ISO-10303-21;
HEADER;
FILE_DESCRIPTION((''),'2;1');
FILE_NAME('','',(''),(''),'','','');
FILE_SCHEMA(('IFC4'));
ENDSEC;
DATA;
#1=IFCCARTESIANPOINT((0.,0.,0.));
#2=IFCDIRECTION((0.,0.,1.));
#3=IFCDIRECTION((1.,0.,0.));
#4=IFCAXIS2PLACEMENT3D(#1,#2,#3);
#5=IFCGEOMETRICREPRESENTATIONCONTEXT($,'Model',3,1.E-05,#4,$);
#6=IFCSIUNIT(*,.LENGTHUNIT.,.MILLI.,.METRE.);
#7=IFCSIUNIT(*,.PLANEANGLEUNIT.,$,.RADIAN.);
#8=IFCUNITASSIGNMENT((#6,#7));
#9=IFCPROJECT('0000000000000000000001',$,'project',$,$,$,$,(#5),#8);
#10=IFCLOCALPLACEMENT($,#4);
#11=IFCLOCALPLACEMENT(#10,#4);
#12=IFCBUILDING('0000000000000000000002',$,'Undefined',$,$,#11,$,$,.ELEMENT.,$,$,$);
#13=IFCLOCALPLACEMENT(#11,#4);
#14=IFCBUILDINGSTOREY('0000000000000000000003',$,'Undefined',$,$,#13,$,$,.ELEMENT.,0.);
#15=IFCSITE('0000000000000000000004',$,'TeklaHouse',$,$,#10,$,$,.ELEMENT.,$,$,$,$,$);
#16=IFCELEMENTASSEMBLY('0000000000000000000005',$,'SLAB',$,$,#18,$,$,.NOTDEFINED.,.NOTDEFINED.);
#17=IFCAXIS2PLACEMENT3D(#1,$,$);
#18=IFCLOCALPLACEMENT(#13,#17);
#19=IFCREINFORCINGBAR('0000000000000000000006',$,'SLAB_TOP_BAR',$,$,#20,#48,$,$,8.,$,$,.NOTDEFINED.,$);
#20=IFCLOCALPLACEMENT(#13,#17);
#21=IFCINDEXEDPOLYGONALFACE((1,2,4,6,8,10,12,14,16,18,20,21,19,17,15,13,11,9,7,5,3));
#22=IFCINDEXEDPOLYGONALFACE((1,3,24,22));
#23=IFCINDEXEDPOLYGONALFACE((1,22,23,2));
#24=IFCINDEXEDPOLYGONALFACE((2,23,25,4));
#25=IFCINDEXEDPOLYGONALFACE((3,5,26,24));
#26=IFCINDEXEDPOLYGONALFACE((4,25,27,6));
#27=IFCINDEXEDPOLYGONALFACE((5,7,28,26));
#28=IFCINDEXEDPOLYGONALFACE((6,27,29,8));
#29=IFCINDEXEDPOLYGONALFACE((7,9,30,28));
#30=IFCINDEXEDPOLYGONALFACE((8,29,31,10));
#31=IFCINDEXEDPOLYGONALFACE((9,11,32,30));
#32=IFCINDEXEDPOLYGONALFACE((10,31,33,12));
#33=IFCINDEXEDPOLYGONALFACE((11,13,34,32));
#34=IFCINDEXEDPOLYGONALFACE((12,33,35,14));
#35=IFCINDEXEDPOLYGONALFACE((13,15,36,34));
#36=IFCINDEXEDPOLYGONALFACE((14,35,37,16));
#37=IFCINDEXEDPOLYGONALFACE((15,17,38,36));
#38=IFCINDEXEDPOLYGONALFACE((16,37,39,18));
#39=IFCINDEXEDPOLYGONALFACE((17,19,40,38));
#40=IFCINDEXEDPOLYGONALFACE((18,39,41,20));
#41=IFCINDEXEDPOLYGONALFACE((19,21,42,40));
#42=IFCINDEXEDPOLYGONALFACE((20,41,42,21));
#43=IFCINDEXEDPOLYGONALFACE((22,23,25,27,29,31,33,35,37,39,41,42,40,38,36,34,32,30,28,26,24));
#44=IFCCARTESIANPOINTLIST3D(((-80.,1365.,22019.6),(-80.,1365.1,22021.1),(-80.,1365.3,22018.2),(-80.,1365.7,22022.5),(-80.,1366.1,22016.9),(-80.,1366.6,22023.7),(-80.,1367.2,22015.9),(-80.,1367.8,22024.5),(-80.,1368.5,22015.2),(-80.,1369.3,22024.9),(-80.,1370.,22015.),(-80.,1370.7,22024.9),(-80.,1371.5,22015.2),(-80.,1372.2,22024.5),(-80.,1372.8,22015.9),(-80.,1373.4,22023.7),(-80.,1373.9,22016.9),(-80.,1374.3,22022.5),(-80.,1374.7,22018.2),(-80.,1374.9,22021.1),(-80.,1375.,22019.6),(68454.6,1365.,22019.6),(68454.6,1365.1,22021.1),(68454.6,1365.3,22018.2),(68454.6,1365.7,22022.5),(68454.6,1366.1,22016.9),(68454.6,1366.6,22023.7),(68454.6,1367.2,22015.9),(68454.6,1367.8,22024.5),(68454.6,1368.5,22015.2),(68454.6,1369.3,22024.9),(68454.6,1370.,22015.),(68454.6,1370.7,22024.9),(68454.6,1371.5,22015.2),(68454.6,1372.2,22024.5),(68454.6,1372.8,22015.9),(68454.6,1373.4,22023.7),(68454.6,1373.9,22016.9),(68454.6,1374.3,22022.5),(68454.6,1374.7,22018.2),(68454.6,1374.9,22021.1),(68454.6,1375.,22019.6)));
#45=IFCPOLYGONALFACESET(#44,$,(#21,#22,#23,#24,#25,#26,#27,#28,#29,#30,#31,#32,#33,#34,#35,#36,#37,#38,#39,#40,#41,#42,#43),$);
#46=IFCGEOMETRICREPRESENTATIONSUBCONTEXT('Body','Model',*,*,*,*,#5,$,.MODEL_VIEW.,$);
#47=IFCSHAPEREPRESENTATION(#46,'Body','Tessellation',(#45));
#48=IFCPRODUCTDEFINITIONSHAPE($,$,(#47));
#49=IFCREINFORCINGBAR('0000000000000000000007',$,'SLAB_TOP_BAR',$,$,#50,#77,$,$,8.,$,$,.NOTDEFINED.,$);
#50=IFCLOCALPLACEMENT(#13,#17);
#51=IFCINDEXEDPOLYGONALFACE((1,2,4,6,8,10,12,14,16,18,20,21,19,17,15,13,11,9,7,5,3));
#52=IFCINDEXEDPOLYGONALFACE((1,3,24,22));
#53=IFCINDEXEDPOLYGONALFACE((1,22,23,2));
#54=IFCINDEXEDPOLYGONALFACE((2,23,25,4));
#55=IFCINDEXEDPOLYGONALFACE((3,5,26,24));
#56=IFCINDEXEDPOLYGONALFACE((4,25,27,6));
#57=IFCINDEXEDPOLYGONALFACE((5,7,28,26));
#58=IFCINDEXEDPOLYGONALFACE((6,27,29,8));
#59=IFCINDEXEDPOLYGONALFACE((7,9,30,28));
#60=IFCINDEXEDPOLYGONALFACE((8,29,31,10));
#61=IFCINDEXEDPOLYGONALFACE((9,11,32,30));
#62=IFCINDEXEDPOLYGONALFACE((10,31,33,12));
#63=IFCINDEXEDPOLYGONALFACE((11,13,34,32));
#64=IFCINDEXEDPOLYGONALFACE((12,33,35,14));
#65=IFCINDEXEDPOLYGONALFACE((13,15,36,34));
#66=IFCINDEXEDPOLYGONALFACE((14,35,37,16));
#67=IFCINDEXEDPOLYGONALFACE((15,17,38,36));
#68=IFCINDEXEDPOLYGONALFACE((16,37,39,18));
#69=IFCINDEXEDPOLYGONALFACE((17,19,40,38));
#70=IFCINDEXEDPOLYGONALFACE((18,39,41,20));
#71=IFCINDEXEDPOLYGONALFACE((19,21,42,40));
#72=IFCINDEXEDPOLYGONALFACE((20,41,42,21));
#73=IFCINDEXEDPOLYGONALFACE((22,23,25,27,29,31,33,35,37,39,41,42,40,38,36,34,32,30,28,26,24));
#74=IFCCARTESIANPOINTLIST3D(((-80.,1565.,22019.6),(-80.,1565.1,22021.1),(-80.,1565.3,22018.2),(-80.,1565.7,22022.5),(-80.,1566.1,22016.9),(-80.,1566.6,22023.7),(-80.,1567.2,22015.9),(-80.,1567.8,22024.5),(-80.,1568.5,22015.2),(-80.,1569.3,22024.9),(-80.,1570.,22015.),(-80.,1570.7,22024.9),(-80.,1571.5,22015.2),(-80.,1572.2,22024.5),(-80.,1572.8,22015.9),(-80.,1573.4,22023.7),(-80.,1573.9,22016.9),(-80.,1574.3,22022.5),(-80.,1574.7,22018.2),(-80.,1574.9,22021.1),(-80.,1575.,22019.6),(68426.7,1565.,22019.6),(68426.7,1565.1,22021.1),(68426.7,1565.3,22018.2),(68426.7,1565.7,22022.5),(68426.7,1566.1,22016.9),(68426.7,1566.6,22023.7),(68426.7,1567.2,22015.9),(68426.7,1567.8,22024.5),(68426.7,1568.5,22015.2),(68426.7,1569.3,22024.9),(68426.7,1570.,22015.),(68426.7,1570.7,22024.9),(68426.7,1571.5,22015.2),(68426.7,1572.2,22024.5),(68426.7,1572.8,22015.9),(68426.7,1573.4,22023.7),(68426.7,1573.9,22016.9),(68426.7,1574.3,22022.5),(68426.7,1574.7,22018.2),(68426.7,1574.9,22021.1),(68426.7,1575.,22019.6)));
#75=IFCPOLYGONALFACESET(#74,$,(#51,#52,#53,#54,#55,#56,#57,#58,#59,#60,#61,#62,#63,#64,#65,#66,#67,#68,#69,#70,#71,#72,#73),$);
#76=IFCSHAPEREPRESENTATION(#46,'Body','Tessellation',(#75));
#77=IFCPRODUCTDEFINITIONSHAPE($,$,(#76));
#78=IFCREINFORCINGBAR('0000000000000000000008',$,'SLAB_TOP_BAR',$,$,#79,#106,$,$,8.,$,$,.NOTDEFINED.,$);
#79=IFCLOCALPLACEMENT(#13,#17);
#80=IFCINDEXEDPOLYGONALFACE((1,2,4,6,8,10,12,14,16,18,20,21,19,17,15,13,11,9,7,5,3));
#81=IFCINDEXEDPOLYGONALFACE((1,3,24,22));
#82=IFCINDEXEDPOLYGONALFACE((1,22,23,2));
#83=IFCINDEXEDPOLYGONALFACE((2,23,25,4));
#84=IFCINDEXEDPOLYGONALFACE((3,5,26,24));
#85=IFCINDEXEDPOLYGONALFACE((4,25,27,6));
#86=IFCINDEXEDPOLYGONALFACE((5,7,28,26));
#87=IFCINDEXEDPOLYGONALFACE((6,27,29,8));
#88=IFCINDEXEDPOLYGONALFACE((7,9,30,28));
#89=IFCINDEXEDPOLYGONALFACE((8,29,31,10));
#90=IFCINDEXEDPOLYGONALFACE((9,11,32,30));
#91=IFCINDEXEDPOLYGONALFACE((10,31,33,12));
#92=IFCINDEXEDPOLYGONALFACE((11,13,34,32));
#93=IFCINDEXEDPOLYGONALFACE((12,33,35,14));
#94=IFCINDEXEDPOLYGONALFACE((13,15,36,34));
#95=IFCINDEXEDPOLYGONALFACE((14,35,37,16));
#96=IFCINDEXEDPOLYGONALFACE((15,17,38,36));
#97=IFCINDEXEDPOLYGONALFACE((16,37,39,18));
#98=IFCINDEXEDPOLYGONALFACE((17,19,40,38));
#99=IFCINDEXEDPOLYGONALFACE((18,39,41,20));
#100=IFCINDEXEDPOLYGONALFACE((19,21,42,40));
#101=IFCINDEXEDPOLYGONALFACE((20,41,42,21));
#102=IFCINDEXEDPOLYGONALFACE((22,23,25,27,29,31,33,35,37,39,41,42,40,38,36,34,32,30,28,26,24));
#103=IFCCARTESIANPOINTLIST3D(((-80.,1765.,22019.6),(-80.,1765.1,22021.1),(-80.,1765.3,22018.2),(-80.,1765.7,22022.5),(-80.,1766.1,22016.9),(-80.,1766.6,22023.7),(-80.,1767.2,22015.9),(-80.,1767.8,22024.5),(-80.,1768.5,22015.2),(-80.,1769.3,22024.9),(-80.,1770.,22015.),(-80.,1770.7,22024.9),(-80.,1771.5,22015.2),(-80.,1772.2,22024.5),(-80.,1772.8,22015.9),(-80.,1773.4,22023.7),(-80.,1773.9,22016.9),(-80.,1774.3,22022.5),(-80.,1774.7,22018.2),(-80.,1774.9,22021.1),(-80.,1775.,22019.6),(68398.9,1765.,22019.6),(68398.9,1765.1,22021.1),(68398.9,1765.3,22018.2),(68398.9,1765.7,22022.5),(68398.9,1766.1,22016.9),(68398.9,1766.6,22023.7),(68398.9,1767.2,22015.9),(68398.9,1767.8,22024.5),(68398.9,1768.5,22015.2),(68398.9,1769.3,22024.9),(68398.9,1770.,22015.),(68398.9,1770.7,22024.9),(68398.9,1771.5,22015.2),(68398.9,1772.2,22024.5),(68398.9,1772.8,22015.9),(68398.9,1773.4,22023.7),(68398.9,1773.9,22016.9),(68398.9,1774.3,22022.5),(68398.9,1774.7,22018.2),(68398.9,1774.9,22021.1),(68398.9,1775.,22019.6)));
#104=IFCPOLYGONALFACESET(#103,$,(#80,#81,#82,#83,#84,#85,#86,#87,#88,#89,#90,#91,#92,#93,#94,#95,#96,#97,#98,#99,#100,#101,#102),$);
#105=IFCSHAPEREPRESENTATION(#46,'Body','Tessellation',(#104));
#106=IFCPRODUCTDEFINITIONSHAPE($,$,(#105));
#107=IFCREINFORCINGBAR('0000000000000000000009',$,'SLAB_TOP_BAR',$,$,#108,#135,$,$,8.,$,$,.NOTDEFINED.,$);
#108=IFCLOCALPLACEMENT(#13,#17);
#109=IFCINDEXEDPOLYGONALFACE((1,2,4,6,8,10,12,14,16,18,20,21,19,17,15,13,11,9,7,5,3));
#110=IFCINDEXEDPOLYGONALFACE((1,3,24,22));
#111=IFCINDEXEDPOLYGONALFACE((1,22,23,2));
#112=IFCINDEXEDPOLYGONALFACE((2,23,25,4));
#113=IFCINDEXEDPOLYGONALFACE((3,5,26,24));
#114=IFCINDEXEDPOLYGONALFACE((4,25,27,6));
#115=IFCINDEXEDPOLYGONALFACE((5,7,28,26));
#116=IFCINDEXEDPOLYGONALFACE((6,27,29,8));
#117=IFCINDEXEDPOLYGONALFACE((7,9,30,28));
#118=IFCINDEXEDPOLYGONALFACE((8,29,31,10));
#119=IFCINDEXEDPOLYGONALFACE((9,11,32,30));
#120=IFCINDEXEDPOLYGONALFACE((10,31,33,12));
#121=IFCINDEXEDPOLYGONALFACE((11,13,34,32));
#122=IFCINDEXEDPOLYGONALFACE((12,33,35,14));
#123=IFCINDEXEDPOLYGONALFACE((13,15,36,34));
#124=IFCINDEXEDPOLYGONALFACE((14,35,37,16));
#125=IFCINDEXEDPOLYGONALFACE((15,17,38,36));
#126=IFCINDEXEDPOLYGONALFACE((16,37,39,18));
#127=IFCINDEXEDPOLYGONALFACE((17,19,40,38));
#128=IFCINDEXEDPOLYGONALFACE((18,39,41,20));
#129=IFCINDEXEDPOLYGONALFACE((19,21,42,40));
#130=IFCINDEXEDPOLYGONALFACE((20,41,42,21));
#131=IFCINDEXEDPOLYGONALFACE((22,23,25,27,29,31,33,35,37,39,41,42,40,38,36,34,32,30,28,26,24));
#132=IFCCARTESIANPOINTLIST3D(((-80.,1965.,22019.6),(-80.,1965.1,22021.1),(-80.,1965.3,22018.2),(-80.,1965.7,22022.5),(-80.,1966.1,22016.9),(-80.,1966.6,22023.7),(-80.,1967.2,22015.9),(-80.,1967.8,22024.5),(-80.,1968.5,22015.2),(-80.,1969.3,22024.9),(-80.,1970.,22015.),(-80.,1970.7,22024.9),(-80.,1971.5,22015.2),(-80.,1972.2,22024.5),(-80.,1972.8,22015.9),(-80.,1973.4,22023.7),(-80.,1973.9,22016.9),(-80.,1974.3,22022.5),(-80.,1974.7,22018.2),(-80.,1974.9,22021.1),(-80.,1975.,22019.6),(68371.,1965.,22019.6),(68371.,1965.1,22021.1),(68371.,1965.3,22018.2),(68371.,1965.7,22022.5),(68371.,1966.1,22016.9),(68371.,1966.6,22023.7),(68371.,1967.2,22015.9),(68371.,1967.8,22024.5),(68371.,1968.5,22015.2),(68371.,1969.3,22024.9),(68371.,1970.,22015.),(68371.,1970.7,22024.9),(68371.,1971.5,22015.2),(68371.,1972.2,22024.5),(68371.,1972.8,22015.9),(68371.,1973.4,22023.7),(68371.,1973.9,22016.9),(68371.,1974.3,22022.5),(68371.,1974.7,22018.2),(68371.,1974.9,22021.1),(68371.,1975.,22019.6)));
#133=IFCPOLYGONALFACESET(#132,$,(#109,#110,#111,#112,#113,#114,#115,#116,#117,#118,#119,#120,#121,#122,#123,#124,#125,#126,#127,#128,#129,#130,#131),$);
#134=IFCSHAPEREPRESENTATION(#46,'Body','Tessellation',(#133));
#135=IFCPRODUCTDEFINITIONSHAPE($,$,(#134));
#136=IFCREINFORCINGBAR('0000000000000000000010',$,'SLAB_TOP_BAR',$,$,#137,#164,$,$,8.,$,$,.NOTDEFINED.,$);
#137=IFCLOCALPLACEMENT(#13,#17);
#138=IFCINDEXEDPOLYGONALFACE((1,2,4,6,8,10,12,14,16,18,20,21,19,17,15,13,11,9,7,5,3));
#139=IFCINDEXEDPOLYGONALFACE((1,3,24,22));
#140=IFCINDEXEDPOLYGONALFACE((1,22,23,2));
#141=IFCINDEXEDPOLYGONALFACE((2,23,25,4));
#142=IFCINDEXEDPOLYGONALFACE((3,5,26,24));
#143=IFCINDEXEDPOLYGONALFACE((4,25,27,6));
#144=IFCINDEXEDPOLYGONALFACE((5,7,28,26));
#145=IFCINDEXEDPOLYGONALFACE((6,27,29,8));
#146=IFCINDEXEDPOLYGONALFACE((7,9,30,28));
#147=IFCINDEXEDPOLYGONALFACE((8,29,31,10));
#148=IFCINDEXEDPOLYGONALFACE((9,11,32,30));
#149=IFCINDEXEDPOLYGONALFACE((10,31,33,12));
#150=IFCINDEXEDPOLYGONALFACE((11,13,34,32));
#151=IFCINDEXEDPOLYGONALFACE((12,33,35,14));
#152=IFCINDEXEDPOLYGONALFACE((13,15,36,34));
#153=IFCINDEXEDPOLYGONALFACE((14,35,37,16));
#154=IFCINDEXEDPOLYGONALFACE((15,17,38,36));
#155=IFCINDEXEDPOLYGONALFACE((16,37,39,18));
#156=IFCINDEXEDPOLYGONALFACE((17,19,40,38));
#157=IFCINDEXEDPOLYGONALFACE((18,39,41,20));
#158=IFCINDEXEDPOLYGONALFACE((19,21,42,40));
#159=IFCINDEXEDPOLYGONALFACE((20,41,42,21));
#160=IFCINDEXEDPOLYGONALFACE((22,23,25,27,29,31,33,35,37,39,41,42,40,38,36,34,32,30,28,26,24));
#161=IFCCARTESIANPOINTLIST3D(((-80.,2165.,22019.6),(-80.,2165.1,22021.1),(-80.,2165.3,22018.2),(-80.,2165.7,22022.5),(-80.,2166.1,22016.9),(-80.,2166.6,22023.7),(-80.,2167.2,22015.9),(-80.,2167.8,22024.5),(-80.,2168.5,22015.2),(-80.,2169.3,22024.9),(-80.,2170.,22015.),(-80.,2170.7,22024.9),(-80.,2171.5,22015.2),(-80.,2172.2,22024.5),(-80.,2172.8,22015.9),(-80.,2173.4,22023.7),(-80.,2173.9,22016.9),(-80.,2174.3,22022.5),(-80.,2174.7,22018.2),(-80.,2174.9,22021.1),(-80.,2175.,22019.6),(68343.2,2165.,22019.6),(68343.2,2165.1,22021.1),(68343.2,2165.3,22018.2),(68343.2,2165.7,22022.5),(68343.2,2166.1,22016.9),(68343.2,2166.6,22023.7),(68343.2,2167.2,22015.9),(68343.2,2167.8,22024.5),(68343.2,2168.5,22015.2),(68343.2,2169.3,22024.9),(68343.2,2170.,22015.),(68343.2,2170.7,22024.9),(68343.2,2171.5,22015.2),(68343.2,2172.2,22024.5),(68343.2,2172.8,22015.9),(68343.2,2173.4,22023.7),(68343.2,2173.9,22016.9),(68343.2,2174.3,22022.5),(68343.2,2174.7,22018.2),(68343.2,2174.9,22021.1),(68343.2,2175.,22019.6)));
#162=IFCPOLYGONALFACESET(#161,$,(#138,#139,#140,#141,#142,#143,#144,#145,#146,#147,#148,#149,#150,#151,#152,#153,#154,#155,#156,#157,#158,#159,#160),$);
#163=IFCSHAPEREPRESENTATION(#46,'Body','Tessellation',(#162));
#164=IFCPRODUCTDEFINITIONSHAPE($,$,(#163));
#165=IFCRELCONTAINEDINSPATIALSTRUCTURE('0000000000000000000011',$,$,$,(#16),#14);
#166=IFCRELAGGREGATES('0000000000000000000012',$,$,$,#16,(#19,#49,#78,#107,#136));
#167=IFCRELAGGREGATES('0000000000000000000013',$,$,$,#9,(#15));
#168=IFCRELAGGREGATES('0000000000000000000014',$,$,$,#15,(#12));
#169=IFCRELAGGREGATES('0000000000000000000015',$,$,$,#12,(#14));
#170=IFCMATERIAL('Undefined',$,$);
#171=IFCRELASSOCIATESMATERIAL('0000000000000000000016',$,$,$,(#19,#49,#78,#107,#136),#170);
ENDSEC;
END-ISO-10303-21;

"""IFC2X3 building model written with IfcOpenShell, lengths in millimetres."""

from ifc_helpers import new_model, entity, si_unit, frame, origin_with_axes, place, context, subcontext, project, spatial, source, transform, mapped, material, element, aggregate, save


model = new_model("IFC2X3")

# Units and contexts
model_context = context("Model", 3, precision=1e-05, world=origin_with_axes())
body_context = subcontext(model_context, "Body", "Model", "MODEL_VIEW")
ifc_project = project(units=[si_unit("LENGTHUNIT", "METRE", prefix="MILLI"), si_unit("PLANEANGLEUNIT", "RADIAN")], contexts=[model_context])

# Site, building, storey
site_placement = place(None, origin_with_axes())
site = spatial("IfcSite", under=ifc_project, at=site_placement, Name="TeklaHouse", CompositionType="ELEMENT")
building_placement = place(site_placement, origin_with_axes())
building = spatial("IfcBuilding", under=site, at=building_placement, Name="Undefined", CompositionType="ELEMENT")
storey_placement = place(building_placement, origin_with_axes())
storey = spatial("IfcBuildingStorey", under=building, at=storey_placement, Name="Undefined", CompositionType="ELEMENT", Elevation=0.0)

# Shared definitions
ifc_material_1 = material(Name="Undefined")

# Element assembly, reinforcing bars
assembly_1_placement = place(storey_placement, origin_with_axes())
assembly_1 = element("IfcElementAssembly", 1, at=assembly_1_placement, inside=storey, Name="SLAB", AssemblyPlace="NOTDEFINED", PredefinedType="NOTDEFINED")
shared_shape_1 = source(origin_with_axes(), body_context, "Body", "AdvancedSweptSolid", [
    entity("IfcSweptDiskSolid", entity("IfcTrimmedCurve", entity("IfcLine", entity("IfcCartesianPoint", [0.0, 0.0, 0.0]), entity("IfcVector", entity("IfcDirection", [1.0, 0.0, 0.0]), 1.0)), [entity("IfcParameterValue", 0.0)], [entity("IfcParameterValue", 68534.587508)], True, "PARAMETER"), 5.0, None, 0.0, 68534.6),
])
reinforcing_bar_1_placement = place(assembly_1_placement, frame((68454.6, 1370.0, 22020.0), z_axis=(0.0, 0.0, -1.0), x_axis=(-1.0, 0.0, 0.0)))
reinforcing_bar_1 = element("IfcReinforcingBar", 2, at=reinforcing_bar_1_placement, material=ifc_material_1, Name="SLAB_TOP_BAR", BarRole="NOTDEFINED", NominalDiameter=8.0, context=body_context, shape_type="MappedRepresentation", body=[
    mapped(shared_shape_1, transform((0.0, 0.0, 0.0))),
])
shared_shape_2 = source(origin_with_axes(), body_context, "Body", "AdvancedSweptSolid", [
    entity("IfcSweptDiskSolid", entity("IfcTrimmedCurve", entity("IfcLine", entity("IfcCartesianPoint", [0.0, 0.0, 0.0]), entity("IfcVector", entity("IfcDirection", [1.0, 0.0, 0.0]), 1.0)), [entity("IfcParameterValue", 0.0)], [entity("IfcParameterValue", 68506.741051)], True, "PARAMETER"), 5.0, None, 0.0, 68506.7),
])
reinforcing_bar_2_placement = place(assembly_1_placement, frame((68426.7, 1570.0, 22020.0), z_axis=(0.0, 0.0, -1.0), x_axis=(-1.0, 0.0, 0.0)))
reinforcing_bar_2 = element("IfcReinforcingBar", 3, at=reinforcing_bar_2_placement, material=ifc_material_1, Name="SLAB_TOP_BAR", BarRole="NOTDEFINED", NominalDiameter=8.0, context=body_context, shape_type="MappedRepresentation", body=[
    mapped(shared_shape_2, transform((0.0, 0.0, 0.0))),
])
shared_shape_3 = source(origin_with_axes(), body_context, "Body", "AdvancedSweptSolid", [
    entity("IfcSweptDiskSolid", entity("IfcTrimmedCurve", entity("IfcLine", entity("IfcCartesianPoint", [0.0, 0.0, 0.0]), entity("IfcVector", entity("IfcDirection", [1.0, 0.0, 0.0]), 1.0)), [entity("IfcParameterValue", 0.0)], [entity("IfcParameterValue", 68478.894594)], True, "PARAMETER"), 5.0, None, 0.0, 68478.9),
])
reinforcing_bar_3_placement = place(assembly_1_placement, frame((68398.9, 1770.0, 22020.0), z_axis=(0.0, 0.0, -1.0), x_axis=(-1.0, 0.0, 0.0)))
reinforcing_bar_3 = element("IfcReinforcingBar", 4, at=reinforcing_bar_3_placement, material=ifc_material_1, Name="SLAB_TOP_BAR", BarRole="NOTDEFINED", NominalDiameter=8.0, context=body_context, shape_type="MappedRepresentation", body=[
    mapped(shared_shape_3, transform((0.0, 0.0, 0.0))),
])
shared_shape_4 = source(origin_with_axes(), body_context, "Body", "AdvancedSweptSolid", [
    entity("IfcSweptDiskSolid", entity("IfcTrimmedCurve", entity("IfcLine", entity("IfcCartesianPoint", [0.0, 0.0, 0.0]), entity("IfcVector", entity("IfcDirection", [1.0, 0.0, 0.0]), 1.0)), [entity("IfcParameterValue", 0.0)], [entity("IfcParameterValue", 68451.048137)], True, "PARAMETER"), 5.0, None, 0.0, 68451.0),
])
reinforcing_bar_4_placement = place(assembly_1_placement, frame((68371.0, 1970.0, 22020.0), z_axis=(0.0, 0.0, -1.0), x_axis=(-1.0, 0.0, 0.0)))
reinforcing_bar_4 = element("IfcReinforcingBar", 5, at=reinforcing_bar_4_placement, material=ifc_material_1, Name="SLAB_TOP_BAR", BarRole="NOTDEFINED", NominalDiameter=8.0, context=body_context, shape_type="MappedRepresentation", body=[
    mapped(shared_shape_4, transform((0.0, 0.0, 0.0))),
])
shared_shape_5 = source(origin_with_axes(), body_context, "Body", "AdvancedSweptSolid", [
    entity("IfcSweptDiskSolid", entity("IfcTrimmedCurve", entity("IfcLine", entity("IfcCartesianPoint", [0.0, 0.0, 0.0]), entity("IfcVector", entity("IfcDirection", [1.0, 0.0, 0.0]), 1.0)), [entity("IfcParameterValue", 0.0)], [entity("IfcParameterValue", 68423.20168)], True, "PARAMETER"), 5.0, None, 0.0, 68423.2),
])
reinforcing_bar_5_placement = place(assembly_1_placement, frame((68343.2, 2170.0, 22020.0), z_axis=(0.0, 0.0, -1.0), x_axis=(-1.0, 0.0, 0.0)))
reinforcing_bar_5 = element("IfcReinforcingBar", 6, at=reinforcing_bar_5_placement, material=ifc_material_1, Name="SLAB_TOP_BAR", BarRole="NOTDEFINED", NominalDiameter=8.0, context=body_context, shape_type="MappedRepresentation", body=[
    mapped(shared_shape_5, transform((0.0, 0.0, 0.0))),
])
aggregate(assembly_1, [reinforcing_bar_1, reinforcing_bar_2, reinforcing_bar_3, reinforcing_bar_4, reinforcing_bar_5])

save(model, "model.ifc")
